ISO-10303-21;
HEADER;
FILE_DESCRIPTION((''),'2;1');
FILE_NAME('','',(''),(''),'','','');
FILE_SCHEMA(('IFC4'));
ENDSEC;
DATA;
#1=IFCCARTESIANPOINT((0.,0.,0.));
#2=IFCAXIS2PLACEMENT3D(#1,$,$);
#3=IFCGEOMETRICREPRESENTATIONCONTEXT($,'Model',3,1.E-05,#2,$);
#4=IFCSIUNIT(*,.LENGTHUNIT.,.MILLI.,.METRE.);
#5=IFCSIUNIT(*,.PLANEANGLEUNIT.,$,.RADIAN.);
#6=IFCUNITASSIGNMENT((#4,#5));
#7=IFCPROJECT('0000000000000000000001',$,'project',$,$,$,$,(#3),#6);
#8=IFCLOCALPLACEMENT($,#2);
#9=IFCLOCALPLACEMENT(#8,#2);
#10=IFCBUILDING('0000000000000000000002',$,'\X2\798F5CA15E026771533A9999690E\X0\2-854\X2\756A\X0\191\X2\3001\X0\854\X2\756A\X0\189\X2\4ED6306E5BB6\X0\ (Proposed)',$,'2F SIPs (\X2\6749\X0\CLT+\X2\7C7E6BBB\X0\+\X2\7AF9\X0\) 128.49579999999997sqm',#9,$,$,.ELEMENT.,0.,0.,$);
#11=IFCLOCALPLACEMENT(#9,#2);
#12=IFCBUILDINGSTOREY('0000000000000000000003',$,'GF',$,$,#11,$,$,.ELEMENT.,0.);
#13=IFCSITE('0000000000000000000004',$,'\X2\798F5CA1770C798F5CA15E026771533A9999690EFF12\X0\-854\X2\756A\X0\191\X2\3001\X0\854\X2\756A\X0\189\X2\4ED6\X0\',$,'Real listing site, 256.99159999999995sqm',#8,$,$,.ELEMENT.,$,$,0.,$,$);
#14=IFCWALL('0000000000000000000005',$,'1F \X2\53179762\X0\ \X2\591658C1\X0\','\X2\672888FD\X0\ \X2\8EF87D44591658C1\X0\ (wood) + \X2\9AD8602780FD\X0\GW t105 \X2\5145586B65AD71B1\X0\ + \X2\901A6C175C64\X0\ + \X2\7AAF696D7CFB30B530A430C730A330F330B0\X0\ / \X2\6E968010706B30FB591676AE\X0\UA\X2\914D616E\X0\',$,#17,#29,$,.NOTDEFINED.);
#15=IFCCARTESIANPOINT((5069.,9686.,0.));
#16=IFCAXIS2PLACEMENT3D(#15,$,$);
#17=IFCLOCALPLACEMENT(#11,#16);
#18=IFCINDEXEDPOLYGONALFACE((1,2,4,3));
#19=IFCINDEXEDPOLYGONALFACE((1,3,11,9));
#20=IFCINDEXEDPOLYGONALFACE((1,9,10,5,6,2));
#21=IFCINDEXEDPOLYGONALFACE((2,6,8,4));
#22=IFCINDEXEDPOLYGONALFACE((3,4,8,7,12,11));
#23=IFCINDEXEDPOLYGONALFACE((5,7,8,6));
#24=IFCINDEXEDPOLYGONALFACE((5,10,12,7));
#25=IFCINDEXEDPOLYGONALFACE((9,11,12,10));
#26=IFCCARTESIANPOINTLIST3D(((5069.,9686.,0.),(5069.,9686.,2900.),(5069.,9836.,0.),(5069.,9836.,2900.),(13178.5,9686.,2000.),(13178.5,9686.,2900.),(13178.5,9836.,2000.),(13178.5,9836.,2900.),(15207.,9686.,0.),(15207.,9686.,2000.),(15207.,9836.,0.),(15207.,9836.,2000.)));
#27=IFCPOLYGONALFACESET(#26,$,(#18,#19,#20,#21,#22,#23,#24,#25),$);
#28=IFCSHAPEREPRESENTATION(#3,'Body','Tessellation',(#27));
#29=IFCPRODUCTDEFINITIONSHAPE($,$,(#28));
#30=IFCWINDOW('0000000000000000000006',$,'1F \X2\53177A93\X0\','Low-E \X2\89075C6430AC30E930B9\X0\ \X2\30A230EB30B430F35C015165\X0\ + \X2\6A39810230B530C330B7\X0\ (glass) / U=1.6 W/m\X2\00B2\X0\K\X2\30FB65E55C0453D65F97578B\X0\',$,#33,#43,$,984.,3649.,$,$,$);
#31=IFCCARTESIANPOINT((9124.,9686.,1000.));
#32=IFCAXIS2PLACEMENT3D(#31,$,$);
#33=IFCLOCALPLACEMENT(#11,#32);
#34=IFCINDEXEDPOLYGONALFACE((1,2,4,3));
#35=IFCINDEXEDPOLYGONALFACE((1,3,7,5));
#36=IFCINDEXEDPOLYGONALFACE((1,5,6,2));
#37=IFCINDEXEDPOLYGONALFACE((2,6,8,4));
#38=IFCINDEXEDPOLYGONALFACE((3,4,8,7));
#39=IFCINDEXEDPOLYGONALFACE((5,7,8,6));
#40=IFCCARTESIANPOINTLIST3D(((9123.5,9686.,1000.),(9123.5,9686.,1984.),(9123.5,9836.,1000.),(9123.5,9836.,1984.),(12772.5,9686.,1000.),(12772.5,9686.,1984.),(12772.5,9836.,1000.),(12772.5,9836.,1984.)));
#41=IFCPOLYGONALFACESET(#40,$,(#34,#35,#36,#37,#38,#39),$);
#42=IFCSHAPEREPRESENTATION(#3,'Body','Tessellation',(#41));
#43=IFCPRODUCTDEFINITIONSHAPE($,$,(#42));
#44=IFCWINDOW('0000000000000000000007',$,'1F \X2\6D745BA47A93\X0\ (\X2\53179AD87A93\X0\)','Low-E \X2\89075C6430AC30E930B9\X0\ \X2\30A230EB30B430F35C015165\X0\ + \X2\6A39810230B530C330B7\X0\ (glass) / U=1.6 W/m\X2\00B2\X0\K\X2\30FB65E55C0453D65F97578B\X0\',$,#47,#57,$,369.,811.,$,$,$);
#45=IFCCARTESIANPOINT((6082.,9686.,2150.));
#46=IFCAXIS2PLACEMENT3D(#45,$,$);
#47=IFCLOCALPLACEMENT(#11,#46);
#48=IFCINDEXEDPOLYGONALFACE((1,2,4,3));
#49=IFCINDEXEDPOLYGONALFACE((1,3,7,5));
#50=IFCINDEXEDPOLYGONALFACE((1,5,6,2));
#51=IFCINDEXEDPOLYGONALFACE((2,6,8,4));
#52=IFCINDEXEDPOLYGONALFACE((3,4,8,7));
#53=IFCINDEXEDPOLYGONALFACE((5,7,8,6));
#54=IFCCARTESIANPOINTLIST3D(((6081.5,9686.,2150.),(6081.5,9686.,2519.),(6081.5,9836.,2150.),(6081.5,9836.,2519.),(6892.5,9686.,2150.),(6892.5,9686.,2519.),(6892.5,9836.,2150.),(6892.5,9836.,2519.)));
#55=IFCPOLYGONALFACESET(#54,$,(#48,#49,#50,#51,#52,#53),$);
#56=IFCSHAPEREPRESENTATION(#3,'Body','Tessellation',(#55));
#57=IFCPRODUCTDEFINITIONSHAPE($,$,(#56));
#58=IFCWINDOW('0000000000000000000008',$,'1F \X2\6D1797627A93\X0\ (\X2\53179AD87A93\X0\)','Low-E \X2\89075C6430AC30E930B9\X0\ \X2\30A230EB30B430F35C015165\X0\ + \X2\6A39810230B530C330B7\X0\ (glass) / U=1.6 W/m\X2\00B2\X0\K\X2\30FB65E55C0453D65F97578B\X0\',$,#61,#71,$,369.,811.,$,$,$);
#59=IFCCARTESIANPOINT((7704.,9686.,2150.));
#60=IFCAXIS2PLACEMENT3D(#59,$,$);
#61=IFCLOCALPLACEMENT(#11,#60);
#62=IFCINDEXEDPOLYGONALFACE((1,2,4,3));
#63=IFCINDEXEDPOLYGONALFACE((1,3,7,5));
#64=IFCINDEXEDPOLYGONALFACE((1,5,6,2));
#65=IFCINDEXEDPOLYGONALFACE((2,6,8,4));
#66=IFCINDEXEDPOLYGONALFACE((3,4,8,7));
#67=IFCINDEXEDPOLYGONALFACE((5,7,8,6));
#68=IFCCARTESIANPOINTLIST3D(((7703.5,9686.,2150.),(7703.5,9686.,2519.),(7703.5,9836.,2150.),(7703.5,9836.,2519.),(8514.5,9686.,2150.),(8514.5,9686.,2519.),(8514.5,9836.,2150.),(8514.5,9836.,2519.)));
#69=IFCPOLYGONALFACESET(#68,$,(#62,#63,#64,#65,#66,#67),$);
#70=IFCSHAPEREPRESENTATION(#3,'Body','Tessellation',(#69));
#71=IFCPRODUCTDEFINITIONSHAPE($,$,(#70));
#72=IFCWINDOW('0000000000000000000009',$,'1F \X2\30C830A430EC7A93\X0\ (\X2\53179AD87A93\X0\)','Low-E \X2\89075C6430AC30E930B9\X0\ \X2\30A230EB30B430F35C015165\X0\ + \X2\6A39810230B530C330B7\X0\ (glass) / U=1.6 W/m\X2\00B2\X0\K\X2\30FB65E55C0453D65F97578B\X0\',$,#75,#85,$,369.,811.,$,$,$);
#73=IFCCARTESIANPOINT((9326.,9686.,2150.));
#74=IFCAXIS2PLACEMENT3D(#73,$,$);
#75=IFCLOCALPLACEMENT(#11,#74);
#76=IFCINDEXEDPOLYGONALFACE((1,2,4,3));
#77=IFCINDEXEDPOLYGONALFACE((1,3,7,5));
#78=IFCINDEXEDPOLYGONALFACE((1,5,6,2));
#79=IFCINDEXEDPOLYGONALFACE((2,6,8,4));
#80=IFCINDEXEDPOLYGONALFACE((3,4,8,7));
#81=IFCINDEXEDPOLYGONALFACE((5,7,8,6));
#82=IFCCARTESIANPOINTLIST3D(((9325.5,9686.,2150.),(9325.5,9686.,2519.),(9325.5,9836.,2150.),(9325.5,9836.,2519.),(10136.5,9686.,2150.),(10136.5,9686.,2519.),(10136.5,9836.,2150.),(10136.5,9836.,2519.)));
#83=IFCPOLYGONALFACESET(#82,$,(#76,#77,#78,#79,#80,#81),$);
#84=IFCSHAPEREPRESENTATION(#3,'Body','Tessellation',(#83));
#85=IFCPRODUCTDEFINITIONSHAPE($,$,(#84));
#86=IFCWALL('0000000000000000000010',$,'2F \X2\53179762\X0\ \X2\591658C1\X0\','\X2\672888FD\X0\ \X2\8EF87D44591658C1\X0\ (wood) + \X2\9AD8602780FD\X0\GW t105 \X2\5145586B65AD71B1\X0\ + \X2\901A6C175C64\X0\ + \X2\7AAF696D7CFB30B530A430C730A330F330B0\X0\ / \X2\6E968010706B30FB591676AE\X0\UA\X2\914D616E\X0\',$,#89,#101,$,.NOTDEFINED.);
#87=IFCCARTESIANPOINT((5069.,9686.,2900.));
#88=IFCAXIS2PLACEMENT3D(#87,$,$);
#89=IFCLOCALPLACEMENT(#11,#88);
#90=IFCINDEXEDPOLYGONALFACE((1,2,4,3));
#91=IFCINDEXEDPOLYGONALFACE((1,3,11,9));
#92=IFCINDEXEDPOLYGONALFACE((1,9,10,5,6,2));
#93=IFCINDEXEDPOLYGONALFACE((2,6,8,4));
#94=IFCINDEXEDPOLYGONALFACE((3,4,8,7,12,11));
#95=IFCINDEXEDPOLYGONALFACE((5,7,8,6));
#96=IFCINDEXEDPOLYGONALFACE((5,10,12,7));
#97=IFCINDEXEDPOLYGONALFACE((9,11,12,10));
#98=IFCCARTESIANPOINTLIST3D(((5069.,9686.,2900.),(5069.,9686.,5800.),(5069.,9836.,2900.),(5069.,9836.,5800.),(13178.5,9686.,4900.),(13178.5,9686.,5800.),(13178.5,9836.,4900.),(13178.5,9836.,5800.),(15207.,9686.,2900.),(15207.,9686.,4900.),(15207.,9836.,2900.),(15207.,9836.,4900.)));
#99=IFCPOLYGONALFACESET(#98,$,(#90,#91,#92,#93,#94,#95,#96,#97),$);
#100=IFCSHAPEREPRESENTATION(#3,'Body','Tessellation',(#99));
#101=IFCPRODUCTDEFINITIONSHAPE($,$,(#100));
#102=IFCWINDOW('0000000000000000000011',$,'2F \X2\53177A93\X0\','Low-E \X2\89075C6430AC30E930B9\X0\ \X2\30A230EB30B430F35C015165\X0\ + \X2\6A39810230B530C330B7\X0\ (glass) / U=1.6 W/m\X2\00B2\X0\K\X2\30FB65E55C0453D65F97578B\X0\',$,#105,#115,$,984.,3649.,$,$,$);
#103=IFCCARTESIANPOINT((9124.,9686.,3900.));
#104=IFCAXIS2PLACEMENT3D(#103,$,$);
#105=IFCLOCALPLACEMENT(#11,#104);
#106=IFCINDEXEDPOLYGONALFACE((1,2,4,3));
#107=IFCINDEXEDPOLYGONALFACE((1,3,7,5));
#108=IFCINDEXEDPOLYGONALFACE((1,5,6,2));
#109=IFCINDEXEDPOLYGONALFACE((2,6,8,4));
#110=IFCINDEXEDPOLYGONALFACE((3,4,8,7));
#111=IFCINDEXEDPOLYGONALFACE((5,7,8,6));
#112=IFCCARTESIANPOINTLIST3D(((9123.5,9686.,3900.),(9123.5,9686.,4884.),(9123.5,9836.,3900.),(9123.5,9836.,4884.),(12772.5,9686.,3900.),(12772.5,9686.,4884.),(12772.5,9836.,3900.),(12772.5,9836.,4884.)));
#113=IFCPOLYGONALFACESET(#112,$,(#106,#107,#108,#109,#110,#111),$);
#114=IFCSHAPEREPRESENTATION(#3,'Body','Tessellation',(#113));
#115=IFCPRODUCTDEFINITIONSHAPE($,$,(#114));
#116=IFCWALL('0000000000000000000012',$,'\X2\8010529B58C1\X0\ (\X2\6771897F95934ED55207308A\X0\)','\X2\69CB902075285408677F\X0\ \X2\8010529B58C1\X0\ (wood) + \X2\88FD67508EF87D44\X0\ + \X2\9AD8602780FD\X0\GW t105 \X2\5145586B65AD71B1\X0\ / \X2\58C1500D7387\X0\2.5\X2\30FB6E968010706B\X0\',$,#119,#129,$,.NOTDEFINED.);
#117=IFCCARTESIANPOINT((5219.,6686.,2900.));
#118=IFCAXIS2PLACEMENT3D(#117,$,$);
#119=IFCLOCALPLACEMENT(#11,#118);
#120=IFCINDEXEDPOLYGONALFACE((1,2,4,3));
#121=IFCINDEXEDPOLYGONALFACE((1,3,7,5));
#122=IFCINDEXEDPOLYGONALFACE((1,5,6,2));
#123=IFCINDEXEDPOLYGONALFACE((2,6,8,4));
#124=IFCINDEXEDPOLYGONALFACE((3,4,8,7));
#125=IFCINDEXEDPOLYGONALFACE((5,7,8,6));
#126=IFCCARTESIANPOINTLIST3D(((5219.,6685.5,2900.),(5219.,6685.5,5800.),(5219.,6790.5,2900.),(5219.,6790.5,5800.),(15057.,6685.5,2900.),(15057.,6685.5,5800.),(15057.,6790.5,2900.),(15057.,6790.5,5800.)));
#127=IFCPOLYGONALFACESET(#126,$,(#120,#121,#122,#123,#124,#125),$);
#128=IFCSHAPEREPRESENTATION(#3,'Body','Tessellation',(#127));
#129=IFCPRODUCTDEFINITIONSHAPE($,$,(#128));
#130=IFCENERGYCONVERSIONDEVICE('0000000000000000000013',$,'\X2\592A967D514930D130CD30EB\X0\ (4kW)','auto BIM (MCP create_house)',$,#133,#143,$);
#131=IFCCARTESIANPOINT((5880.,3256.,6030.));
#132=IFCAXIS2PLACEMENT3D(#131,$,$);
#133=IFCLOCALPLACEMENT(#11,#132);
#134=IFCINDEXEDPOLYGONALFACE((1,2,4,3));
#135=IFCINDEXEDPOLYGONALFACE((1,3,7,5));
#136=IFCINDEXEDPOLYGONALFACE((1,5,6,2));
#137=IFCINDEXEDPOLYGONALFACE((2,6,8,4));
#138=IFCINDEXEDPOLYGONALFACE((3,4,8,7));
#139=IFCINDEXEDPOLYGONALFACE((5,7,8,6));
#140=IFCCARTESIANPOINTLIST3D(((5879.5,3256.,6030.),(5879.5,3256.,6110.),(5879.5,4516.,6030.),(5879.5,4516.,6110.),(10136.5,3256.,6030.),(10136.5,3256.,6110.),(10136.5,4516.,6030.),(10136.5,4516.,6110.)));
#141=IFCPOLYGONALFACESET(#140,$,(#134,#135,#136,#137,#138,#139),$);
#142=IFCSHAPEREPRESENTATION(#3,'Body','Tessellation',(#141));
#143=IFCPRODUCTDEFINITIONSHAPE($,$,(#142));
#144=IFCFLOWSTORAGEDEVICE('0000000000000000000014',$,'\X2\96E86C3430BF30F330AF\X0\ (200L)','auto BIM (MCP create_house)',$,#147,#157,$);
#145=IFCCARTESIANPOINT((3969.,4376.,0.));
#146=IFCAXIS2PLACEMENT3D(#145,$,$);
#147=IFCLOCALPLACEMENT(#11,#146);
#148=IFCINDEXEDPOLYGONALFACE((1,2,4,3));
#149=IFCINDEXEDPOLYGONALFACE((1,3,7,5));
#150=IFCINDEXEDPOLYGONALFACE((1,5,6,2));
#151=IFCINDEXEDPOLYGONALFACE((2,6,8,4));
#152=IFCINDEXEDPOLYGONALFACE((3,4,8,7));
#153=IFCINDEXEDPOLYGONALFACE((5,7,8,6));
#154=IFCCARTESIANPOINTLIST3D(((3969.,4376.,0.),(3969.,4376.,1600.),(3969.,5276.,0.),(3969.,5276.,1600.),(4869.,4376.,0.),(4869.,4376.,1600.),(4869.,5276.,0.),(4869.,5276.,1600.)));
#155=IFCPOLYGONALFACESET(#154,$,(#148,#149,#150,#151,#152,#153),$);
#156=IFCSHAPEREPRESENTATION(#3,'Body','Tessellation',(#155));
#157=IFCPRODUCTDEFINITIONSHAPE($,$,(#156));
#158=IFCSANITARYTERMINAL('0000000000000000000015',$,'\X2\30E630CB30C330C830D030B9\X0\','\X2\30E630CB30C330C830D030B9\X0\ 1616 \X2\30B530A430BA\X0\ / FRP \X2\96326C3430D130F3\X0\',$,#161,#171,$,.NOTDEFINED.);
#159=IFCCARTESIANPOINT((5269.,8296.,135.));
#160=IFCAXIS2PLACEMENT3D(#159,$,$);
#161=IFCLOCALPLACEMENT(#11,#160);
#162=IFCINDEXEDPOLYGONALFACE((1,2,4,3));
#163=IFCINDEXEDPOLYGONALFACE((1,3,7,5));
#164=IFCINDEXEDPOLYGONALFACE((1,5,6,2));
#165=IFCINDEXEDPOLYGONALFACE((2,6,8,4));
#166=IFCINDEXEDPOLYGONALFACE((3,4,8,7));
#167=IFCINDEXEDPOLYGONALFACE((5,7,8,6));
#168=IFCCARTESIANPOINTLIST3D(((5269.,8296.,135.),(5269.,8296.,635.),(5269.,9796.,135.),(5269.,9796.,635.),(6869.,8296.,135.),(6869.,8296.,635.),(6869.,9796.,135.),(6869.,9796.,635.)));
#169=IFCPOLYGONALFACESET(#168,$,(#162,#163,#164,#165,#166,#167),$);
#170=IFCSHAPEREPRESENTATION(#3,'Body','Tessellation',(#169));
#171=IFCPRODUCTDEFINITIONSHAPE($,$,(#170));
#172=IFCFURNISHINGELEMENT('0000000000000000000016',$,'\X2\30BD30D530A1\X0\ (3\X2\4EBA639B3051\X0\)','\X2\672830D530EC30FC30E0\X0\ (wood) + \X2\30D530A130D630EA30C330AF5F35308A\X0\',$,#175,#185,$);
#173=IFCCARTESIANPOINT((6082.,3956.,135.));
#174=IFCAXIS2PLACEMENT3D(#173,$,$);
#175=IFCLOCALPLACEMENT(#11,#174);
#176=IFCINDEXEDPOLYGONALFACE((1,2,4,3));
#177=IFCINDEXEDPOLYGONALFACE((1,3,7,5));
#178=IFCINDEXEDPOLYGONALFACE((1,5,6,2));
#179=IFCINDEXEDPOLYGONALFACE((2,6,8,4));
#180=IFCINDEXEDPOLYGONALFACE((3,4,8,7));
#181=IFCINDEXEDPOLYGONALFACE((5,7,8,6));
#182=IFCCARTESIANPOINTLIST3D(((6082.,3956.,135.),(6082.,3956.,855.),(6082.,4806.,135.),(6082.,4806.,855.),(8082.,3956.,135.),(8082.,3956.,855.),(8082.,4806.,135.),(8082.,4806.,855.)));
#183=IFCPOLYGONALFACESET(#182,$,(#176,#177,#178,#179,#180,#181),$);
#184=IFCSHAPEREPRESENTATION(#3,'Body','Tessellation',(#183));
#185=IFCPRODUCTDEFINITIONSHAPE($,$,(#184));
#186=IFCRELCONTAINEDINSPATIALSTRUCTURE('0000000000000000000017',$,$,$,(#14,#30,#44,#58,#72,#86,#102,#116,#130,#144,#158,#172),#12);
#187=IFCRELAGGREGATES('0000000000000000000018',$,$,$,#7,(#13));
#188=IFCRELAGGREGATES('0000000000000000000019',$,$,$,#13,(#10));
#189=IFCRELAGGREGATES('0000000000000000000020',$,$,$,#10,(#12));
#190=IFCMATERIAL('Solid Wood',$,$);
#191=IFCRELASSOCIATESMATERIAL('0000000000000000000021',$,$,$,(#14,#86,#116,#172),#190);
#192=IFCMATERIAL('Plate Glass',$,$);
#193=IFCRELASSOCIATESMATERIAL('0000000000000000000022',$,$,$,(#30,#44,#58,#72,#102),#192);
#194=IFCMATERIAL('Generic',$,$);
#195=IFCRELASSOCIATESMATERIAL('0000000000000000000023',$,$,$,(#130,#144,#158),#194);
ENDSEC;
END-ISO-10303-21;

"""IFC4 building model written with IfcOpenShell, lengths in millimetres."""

from ifc_helpers import new_model, si_unit, frame, frame_2d, origin, place, context, project, spatial, rectangle, extrude, material, element, fill, save


model = new_model("IFC4")

# Units and contexts
model_context = context("Model", 3, precision=1e-05, world=origin())
ifc_project = project(units=[si_unit("LENGTHUNIT", "METRE", prefix="MILLI"), si_unit("PLANEANGLEUNIT", "RADIAN")], contexts=[model_context])

# Site, building, storey
site_placement = place(None, origin())
site = spatial("IfcSite", under=ifc_project, at=site_placement, Name="福岡県福岡市東区香椎２-854番191、854番189他", ObjectType="Real listing site, 256.99159999999995sqm", CompositionType="ELEMENT", RefElevation=0.0)
building_placement = place(site_placement, origin())
building = spatial("IfcBuilding", under=site, at=building_placement, Name="福岡市東区香椎2-854番191、854番189他の家 (Proposed)", ObjectType="2F SIPs (杉CLT+籾殻+竹) 128.49579999999997sqm", CompositionType="ELEMENT", ElevationOfRefHeight=0.0, ElevationOfTerrain=0.0)
storey_placement = place(building_placement, origin())
storey = spatial("IfcBuildingStorey", under=building, at=storey_placement, Name="GF", CompositionType="ELEMENT", Elevation=0.0)

# Wall, openings, windows
ifc_material_1 = material(Name="Solid Wood")
wall_1_placement = place(storey_placement, frame((5069.0, 9686.0, 0.0)))
wall_1 = element("IfcWall", 1, at=wall_1_placement, inside=storey, material=ifc_material_1, Name="1F 北面 外壁", Description="木製 軸組外壁 (wood) + 高性能GW t105 充填断熱 + 通気層 + 窯業系サイディング / 準耐火・外皮UA配慮", PredefinedType="NOTDEFINED", context=model_context, shape_type="SweptSolid", body=[
    extrude(rectangle(XDim=10138.0, YDim=150.0, at=frame_2d((5069.0, 75.0))), frame((5069.0, 9686.0, 0.0)), (0.0, 0.0, 1.0), 2900.0),
])
opening_1_placement = place(storey_placement, frame((9124.0, 9686.0, 1000.0)))
opening_1 = element("IfcOpeningElement", 2, at=opening_1_placement, cuts=wall_1, PredefinedType="NOTDEFINED", context=model_context, shape_type="SweptSolid", body=[
    extrude(rectangle(XDim=3649.0, YDim=150.0, at=frame_2d((1824.0, 75.0))), frame((9124.0, 9686.0, 1000.0)), (0.0, 0.0, 1.0), 984.0),
])
opening_2_placement = place(storey_placement, frame((6082.0, 9686.0, 2150.0)))
opening_2 = element("IfcOpeningElement", 3, at=opening_2_placement, cuts=wall_1, PredefinedType="NOTDEFINED", context=model_context, shape_type="SweptSolid", body=[
    extrude(rectangle(XDim=811.0, YDim=150.0, at=frame_2d((405.0, 75.0))), frame((6082.0, 9686.0, 2150.0)), (0.0, 0.0, 1.0), 369.0),
])
opening_3_placement = place(storey_placement, frame((7704.0, 9686.0, 2150.0)))
opening_3 = element("IfcOpeningElement", 4, at=opening_3_placement, cuts=wall_1, PredefinedType="NOTDEFINED", context=model_context, shape_type="SweptSolid", body=[
    extrude(rectangle(XDim=811.0, YDim=150.0, at=frame_2d((405.0, 75.0))), frame((7704.0, 9686.0, 2150.0)), (0.0, 0.0, 1.0), 369.0),
])
opening_4_placement = place(storey_placement, frame((9326.0, 9686.0, 2150.0)))
opening_4 = element("IfcOpeningElement", 5, at=opening_4_placement, cuts=wall_1, PredefinedType="NOTDEFINED", context=model_context, shape_type="SweptSolid", body=[
    extrude(rectangle(XDim=811.0, YDim=150.0, at=frame_2d((405.0, 75.0))), frame((9326.0, 9686.0, 2150.0)), (0.0, 0.0, 1.0), 369.0),
])
ifc_material_2 = material(Name="Plate Glass")
window_1_placement = place(storey_placement, frame((9124.0, 9686.0, 1000.0)))
window_1 = element("IfcWindow", 6, at=window_1_placement, inside=storey, material=ifc_material_2, Name="1F 北窓", Description="Low-E 複層ガラス アルゴン封入 + 樹脂サッシ (glass) / U=1.6 W/m²K・日射取得型", OverallHeight=984.0, OverallWidth=3649.0, context=model_context, shape_type="SweptSolid", body=[
    extrude(rectangle(XDim=3649.0, YDim=150.0, at=frame_2d((1824.0, 75.0))), frame((9124.0, 9686.0, 1000.0)), (0.0, 0.0, 1.0), 984.0),
])
fill(opening_1, window_1)
window_2_placement = place(storey_placement, frame((6082.0, 9686.0, 2150.0)))
window_2 = element("IfcWindow", 7, at=window_2_placement, inside=storey, material=ifc_material_2, Name="1F 浴室窓 (北高窓)", Description="Low-E 複層ガラス アルゴン封入 + 樹脂サッシ (glass) / U=1.6 W/m²K・日射取得型", OverallHeight=369.0, OverallWidth=811.0, context=model_context, shape_type="SweptSolid", body=[
    extrude(rectangle(XDim=811.0, YDim=150.0, at=frame_2d((405.0, 75.0))), frame((6082.0, 9686.0, 2150.0)), (0.0, 0.0, 1.0), 369.0),
])
fill(opening_2, window_2)
window_3_placement = place(storey_placement, frame((7704.0, 9686.0, 2150.0)))
window_3 = element("IfcWindow", 8, at=window_3_placement, inside=storey, material=ifc_material_2, Name="1F 洗面窓 (北高窓)", Description="Low-E 複層ガラス アルゴン封入 + 樹脂サッシ (glass) / U=1.6 W/m²K・日射取得型", OverallHeight=369.0, OverallWidth=811.0, context=model_context, shape_type="SweptSolid", body=[
    extrude(rectangle(XDim=811.0, YDim=150.0, at=frame_2d((405.0, 75.0))), frame((7704.0, 9686.0, 2150.0)), (0.0, 0.0, 1.0), 369.0),
])
fill(opening_3, window_3)
window_4_placement = place(storey_placement, frame((9326.0, 9686.0, 2150.0)))
window_4 = element("IfcWindow", 9, at=window_4_placement, inside=storey, material=ifc_material_2, Name="1F トイレ窓 (北高窓)", Description="Low-E 複層ガラス アルゴン封入 + 樹脂サッシ (glass) / U=1.6 W/m²K・日射取得型", OverallHeight=369.0, OverallWidth=811.0, context=model_context, shape_type="SweptSolid", body=[
    extrude(rectangle(XDim=811.0, YDim=150.0, at=frame_2d((405.0, 75.0))), frame((9326.0, 9686.0, 2150.0)), (0.0, 0.0, 1.0), 369.0),
])
fill(opening_4, window_4)

# Wall, opening, window
wall_2_placement = place(storey_placement, frame((5069.0, 9686.0, 2900.0)))
wall_2 = element("IfcWall", 10, at=wall_2_placement, inside=storey, material=ifc_material_1, Name="2F 北面 外壁", Description="木製 軸組外壁 (wood) + 高性能GW t105 充填断熱 + 通気層 + 窯業系サイディング / 準耐火・外皮UA配慮", PredefinedType="NOTDEFINED", context=model_context, shape_type="SweptSolid", body=[
    extrude(rectangle(XDim=10138.0, YDim=150.0, at=frame_2d((5069.0, 75.0))), frame((5069.0, 9686.0, 2900.0)), (0.0, 0.0, 1.0), 2900.0),
])
opening_5_placement = place(storey_placement, frame((9124.0, 9686.0, 3900.0)))
opening_5 = element("IfcOpeningElement", 11, at=opening_5_placement, cuts=wall_2, PredefinedType="NOTDEFINED", context=model_context, shape_type="SweptSolid", body=[
    extrude(rectangle(XDim=3649.0, YDim=150.0, at=frame_2d((1824.0, 75.0))), frame((9124.0, 9686.0, 3900.0)), (0.0, 0.0, 1.0), 984.0),
])
window_5_placement = place(storey_placement, frame((9124.0, 9686.0, 3900.0)))
window_5 = element("IfcWindow", 12, at=window_5_placement, inside=storey, material=ifc_material_2, Name="2F 北窓", Description="Low-E 複層ガラス アルゴン封入 + 樹脂サッシ (glass) / U=1.6 W/m²K・日射取得型", OverallHeight=984.0, OverallWidth=3649.0, context=model_context, shape_type="SweptSolid", body=[
    extrude(rectangle(XDim=3649.0, YDim=150.0, at=frame_2d((1824.0, 75.0))), frame((9124.0, 9686.0, 3900.0)), (0.0, 0.0, 1.0), 984.0),
])
fill(opening_5, window_5)

# Wall
wall_3_placement = place(storey_placement, frame((5219.0, 6686.0, 2900.0)))
element("IfcWall", 13, at=wall_3_placement, inside=storey, material=ifc_material_1, Name="耐力壁 (東西間仕切り)", Description="構造用合板 耐力壁 (wood) + 製材軸組 + 高性能GW t105 充填断熱 / 壁倍率2.5・準耐火", PredefinedType="NOTDEFINED", context=model_context, shape_type="SweptSolid", body=[
    extrude(rectangle(XDim=9838.0, YDim=105.0, at=frame_2d((4919.0, 52.0))), frame((5219.0, 6686.0, 2900.0)), (0.0, 0.0, 1.0), 2900.0),
])

# Energy conversion device
ifc_material_3 = material(Name="Generic")
energy_conversion_device_placement = place(storey_placement, frame((5880.0, 3256.0, 6030.0)))
element("IfcEnergyConversionDevice", 14, at=energy_conversion_device_placement, inside=storey, material=ifc_material_3, Name="太陽光パネル (4kW)", Description="auto BIM (MCP create_house)", context=model_context, shape_type="SweptSolid", body=[
    extrude(rectangle(XDim=4257.0, YDim=1260.0, at=frame_2d((2128.0, 630.0))), frame((5880.0, 3256.0, 6030.0)), (0.0, 0.0, 1.0), 80.0),
])

# Flow storage device
flow_storage_device_placement = place(storey_placement, frame((3969.0, 4376.0, 0.0)))
element("IfcFlowStorageDevice", 15, at=flow_storage_device_placement, inside=storey, material=ifc_material_3, Name="雨水タンク (200L)", Description="auto BIM (MCP create_house)", context=model_context, shape_type="SweptSolid", body=[
    extrude(rectangle(XDim=900.0, YDim=900.0, at=frame_2d((450.0, 450.0))), frame((3969.0, 4376.0, 0.0)), (0.0, 0.0, 1.0), 1600.0),
])

# Sanitary terminal
sanitary_terminal_placement = place(storey_placement, frame((5269.0, 8296.0, 135.0)))
element("IfcSanitaryTerminal", 16, at=sanitary_terminal_placement, inside=storey, material=ifc_material_3, Name="ユニットバス", Description="ユニットバス 1616 サイズ / FRP 防水パン", PredefinedType="NOTDEFINED", context=model_context, shape_type="SweptSolid", body=[
    extrude(rectangle(XDim=1600.0, YDim=1500.0, at=frame_2d((800.0, 750.0))), frame((5269.0, 8296.0, 135.0)), (0.0, 0.0, 1.0), 500.0),
])

# Furnishing element
furnishing_1_placement = place(storey_placement, frame((6082.0, 3956.0, 135.0)))
element("IfcFurnishingElement", 17, at=furnishing_1_placement, inside=storey, material=ifc_material_1, Name="ソファ (3人掛け)", Description="木フレーム (wood) + ファブリック張り", context=model_context, shape_type="SweptSolid", body=[
    extrude(rectangle(XDim=2000.0, YDim=850.0, at=frame_2d((1000.0, 425.0))), frame((6082.0, 3956.0, 135.0)), (0.0, 0.0, 1.0), 720.0),
])

save(model, "model.ifc")
